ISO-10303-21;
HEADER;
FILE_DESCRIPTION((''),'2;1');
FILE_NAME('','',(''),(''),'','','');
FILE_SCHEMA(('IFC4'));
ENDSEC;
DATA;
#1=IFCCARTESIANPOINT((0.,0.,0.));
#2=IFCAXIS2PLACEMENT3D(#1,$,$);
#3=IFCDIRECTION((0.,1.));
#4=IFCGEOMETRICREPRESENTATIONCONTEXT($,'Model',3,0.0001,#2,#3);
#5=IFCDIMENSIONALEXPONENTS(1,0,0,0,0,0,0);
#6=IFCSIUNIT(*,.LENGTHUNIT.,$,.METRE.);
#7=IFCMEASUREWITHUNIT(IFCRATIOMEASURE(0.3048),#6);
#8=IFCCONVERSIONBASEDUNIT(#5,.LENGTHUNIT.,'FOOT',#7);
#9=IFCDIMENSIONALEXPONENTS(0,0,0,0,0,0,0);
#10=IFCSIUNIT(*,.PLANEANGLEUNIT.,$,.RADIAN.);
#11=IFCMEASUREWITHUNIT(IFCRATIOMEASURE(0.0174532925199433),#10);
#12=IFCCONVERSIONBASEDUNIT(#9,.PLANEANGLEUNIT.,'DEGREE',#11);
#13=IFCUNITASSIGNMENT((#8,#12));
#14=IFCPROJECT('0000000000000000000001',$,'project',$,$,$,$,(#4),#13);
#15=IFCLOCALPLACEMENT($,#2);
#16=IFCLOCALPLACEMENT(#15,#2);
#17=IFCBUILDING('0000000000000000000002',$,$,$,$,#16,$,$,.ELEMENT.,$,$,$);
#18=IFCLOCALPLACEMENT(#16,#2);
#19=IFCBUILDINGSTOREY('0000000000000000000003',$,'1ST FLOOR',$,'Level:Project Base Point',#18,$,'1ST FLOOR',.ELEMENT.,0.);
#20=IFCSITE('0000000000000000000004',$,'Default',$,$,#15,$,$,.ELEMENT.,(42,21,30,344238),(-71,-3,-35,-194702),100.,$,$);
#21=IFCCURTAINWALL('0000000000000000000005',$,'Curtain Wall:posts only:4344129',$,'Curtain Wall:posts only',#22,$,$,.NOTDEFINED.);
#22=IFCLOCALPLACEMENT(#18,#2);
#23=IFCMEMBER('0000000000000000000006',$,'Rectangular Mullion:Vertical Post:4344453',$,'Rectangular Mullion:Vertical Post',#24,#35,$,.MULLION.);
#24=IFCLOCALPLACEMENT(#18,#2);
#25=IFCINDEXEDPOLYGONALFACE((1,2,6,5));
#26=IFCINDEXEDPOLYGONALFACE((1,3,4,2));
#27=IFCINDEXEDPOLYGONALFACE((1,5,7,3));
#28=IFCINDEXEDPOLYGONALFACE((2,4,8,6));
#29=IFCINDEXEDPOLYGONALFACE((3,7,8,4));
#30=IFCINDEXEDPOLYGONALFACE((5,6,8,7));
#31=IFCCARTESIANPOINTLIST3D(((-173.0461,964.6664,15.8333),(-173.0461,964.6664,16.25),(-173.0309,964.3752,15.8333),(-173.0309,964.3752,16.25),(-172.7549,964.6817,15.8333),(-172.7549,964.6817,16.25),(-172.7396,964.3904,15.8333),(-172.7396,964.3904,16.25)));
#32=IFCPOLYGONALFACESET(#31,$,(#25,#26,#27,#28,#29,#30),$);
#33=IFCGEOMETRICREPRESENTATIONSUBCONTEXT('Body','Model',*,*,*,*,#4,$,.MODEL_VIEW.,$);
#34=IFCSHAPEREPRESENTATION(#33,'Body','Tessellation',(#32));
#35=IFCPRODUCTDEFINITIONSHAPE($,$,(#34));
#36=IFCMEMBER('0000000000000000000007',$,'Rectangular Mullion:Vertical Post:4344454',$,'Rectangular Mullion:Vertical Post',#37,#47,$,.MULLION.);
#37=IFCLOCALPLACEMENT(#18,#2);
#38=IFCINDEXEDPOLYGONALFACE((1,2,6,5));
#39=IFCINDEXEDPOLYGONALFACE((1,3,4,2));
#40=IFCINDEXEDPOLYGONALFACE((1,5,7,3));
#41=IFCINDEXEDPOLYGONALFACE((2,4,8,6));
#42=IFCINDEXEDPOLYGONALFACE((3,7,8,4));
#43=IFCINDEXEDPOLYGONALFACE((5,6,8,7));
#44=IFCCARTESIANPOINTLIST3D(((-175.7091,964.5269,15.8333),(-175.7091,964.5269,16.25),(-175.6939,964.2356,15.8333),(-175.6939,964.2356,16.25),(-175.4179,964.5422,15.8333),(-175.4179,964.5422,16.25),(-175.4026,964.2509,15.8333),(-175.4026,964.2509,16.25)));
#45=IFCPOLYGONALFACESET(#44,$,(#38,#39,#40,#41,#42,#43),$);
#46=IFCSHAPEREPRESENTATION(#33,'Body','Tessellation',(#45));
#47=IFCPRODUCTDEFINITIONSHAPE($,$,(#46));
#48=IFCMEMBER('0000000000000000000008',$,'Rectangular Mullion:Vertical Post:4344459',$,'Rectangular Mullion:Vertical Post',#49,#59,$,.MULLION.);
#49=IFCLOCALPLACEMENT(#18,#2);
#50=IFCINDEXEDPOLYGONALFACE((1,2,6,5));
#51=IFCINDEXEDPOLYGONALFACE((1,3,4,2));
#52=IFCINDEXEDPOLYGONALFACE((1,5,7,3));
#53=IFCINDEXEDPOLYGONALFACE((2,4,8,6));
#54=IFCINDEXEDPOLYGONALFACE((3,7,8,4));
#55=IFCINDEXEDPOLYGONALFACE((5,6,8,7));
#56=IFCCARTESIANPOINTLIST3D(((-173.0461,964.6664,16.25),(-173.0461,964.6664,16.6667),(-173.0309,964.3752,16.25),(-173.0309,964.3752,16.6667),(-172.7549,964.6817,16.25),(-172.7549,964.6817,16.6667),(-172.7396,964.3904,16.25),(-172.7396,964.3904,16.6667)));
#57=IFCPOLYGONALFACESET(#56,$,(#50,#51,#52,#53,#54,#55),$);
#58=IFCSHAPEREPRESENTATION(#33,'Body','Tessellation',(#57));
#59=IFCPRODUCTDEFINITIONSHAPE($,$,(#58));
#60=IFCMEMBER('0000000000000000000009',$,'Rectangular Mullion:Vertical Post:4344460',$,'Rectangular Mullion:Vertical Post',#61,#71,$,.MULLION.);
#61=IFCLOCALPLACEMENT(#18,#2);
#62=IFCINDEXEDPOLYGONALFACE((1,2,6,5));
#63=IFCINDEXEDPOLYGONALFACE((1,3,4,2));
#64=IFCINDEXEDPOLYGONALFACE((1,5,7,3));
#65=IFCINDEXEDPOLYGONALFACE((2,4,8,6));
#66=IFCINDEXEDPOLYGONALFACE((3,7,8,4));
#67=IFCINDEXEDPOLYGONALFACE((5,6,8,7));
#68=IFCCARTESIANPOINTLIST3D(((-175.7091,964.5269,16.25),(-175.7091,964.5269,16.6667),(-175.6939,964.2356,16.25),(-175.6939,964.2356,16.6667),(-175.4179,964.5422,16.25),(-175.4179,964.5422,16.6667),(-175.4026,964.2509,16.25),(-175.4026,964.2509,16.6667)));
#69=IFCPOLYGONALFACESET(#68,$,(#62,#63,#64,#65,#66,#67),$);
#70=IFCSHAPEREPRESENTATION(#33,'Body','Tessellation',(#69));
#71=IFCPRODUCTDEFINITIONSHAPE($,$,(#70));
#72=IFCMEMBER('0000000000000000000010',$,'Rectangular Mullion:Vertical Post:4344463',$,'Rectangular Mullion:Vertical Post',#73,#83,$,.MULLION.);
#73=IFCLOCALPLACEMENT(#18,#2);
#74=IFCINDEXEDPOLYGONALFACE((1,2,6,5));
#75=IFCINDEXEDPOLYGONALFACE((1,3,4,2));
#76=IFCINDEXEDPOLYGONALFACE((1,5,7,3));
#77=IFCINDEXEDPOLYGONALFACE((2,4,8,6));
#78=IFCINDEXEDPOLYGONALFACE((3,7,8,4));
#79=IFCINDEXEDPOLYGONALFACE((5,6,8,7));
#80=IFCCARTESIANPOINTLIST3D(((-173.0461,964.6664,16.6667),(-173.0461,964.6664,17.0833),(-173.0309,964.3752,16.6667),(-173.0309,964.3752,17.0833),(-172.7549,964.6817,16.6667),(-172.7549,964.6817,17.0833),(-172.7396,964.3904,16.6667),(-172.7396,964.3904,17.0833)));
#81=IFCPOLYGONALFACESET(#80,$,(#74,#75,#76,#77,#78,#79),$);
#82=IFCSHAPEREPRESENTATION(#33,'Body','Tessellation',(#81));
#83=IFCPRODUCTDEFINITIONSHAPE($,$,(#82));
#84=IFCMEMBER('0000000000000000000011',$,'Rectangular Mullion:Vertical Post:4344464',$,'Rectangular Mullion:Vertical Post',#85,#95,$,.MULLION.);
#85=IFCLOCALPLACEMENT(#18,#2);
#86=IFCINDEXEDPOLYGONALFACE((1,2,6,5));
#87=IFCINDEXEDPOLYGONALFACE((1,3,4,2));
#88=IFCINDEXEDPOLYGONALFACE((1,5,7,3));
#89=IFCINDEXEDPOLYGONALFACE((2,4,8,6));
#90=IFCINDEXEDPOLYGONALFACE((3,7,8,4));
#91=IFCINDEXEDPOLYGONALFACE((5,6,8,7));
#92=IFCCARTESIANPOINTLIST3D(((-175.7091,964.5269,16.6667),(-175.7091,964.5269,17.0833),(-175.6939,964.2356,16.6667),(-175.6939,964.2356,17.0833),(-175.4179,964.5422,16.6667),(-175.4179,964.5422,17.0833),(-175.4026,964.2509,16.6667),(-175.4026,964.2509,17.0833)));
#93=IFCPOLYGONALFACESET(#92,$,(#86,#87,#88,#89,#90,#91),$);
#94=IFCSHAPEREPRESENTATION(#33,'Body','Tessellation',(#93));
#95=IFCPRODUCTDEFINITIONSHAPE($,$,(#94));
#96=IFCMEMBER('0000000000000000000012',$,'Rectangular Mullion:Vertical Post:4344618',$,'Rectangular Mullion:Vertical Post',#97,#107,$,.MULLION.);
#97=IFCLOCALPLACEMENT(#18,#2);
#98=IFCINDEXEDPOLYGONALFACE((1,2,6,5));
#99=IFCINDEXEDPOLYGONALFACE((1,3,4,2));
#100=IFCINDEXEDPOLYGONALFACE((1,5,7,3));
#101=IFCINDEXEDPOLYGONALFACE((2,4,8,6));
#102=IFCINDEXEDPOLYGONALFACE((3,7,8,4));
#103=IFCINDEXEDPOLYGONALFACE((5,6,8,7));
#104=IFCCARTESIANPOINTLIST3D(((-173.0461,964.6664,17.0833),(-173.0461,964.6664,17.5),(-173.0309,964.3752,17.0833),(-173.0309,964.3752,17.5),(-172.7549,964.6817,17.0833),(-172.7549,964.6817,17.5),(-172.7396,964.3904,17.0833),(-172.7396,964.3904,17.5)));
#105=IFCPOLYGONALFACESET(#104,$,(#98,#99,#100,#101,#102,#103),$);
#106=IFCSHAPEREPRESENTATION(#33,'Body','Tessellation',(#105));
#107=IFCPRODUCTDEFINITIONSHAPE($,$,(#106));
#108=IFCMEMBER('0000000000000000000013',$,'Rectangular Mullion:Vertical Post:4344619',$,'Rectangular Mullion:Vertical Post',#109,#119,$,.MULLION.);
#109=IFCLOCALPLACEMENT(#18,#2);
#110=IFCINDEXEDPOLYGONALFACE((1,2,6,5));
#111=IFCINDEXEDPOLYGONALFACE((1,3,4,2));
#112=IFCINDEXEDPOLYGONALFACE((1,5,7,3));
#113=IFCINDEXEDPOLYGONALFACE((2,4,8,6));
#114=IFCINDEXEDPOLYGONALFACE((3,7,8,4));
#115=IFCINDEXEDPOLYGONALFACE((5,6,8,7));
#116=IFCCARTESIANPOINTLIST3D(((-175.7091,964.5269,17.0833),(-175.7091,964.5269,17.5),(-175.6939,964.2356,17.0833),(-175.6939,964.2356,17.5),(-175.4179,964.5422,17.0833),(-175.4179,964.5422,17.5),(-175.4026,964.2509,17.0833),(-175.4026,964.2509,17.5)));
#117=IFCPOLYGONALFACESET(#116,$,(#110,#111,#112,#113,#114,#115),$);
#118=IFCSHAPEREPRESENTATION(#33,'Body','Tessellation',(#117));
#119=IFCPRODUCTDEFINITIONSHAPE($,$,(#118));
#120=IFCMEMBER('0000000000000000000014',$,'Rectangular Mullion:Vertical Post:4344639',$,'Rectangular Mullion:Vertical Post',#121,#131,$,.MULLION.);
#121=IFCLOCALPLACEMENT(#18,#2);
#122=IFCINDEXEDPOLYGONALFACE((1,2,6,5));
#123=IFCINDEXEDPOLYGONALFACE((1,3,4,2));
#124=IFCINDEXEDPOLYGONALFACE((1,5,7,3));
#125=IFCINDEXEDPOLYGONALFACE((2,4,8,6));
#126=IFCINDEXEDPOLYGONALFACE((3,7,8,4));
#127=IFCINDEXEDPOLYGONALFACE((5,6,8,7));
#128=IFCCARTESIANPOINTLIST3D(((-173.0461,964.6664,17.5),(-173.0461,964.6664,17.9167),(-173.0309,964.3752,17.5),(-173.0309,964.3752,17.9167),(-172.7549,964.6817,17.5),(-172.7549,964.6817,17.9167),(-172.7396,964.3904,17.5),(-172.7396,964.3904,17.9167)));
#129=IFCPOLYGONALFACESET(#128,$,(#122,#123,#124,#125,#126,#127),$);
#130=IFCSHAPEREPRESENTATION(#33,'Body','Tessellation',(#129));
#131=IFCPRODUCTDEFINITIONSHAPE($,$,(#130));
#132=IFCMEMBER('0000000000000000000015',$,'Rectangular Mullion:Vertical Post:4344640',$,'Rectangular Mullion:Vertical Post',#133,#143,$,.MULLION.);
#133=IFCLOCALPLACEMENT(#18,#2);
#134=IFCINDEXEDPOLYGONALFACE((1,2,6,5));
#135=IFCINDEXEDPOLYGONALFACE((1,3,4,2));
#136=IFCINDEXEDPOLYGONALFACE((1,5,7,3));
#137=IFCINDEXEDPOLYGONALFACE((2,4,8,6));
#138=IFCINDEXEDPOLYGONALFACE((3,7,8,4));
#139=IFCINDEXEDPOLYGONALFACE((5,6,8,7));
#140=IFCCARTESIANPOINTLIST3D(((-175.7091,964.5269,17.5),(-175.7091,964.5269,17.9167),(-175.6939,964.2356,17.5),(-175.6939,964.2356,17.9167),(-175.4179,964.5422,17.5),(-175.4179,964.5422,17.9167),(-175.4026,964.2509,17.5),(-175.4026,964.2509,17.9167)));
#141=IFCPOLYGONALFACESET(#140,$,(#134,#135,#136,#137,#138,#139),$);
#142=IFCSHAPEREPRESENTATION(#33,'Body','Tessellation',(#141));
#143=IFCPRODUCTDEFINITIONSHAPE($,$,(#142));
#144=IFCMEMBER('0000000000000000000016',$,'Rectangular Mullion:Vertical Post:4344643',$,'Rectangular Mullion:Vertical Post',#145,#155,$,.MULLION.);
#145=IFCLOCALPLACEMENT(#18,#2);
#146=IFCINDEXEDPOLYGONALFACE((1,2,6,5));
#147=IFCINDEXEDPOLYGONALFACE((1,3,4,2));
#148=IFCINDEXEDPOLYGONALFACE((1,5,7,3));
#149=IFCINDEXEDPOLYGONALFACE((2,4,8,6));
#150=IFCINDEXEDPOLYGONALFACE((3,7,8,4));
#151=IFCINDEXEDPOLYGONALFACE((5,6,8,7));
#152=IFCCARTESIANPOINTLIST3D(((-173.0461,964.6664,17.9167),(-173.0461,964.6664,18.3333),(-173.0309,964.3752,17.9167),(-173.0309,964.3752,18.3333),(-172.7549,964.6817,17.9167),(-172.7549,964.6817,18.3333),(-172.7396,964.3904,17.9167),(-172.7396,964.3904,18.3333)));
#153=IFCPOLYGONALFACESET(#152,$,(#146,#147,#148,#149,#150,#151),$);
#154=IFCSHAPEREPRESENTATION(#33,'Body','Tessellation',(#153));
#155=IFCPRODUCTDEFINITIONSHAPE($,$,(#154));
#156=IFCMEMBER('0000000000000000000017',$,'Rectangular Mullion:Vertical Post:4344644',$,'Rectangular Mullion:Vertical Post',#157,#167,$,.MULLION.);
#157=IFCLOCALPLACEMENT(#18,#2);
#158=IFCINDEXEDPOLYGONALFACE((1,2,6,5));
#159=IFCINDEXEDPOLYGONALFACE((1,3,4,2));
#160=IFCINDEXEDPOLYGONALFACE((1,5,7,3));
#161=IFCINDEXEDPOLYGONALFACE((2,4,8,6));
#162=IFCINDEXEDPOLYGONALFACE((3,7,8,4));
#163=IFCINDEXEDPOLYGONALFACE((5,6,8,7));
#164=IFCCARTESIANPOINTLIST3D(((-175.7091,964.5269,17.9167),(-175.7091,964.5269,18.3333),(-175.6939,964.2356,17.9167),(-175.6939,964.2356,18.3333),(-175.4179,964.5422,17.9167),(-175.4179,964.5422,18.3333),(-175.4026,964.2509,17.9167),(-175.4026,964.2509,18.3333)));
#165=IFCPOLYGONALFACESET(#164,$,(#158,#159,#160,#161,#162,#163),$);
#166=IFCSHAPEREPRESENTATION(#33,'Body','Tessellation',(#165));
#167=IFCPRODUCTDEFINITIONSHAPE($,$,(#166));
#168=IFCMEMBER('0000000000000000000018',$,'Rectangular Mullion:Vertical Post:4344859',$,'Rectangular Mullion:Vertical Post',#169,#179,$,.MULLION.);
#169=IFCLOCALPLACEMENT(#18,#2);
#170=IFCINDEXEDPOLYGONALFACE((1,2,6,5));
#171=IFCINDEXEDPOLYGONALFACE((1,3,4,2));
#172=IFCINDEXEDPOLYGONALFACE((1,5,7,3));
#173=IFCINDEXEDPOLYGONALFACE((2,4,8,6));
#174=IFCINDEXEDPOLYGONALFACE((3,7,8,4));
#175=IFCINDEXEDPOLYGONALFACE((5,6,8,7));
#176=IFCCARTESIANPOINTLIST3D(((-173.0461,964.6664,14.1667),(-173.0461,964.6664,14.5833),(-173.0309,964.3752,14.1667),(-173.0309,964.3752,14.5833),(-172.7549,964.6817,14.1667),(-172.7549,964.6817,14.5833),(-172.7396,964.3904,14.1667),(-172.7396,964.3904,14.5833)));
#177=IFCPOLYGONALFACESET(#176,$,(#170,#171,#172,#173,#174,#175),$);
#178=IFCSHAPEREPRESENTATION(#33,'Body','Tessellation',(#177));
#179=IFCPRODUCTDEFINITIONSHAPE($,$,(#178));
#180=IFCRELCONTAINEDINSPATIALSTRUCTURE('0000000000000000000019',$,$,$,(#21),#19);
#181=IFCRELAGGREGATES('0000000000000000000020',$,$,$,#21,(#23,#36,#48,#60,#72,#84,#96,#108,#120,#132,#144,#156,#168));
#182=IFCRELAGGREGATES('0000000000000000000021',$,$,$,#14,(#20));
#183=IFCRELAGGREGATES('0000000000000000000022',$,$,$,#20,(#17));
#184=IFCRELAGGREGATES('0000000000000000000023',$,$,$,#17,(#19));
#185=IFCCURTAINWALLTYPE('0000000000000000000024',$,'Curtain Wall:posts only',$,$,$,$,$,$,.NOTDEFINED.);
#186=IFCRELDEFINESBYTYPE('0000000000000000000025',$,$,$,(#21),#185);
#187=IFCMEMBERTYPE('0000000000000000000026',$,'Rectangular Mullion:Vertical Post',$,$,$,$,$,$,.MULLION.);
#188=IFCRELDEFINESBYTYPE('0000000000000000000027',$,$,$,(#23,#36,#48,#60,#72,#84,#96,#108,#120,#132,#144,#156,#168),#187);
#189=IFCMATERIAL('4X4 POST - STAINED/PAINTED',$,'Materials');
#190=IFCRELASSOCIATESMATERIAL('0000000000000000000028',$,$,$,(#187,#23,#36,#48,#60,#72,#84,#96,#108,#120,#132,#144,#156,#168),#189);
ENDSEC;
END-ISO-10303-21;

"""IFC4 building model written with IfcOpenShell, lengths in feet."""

from ifc_helpers import new_model, entity, si_unit, converted_unit, direction, frame, origin, origin_2d_with_axis, place, context, subcontext, project, spatial, rectangle, extrude, source, transform, mapped, material, material_profile, profile_set, profile_usage, type_object, type_shapes, element, aggregate, save


model = new_model("IFC4")

# Units and contexts
model_context = context("Model", 3, precision=0.0001, world=origin(), true_north=direction((0.0, 1.0)))
body_context = subcontext(model_context, "Body", "Model", "MODEL_VIEW")
ifc_project = project(units=[converted_unit("LENGTHUNIT", "FOOT", entity("IfcRatioMeasure", 0.3048), si_unit("LENGTHUNIT", "METRE"), dimensions=[1, 0, 0, 0, 0, 0, 0]), converted_unit("PLANEANGLEUNIT", "DEGREE", entity("IfcRatioMeasure", 0.0174532925199433), si_unit("PLANEANGLEUNIT", "RADIAN"), dimensions=[0, 0, 0, 0, 0, 0, 0])], contexts=[model_context])

# Site, building, storey
site_placement = place(None, origin())
site = spatial("IfcSite", under=ifc_project, at=site_placement, Name="Default", CompositionType="ELEMENT", RefLatitude=(42, 21, 30, 344238), RefLongitude=(-71, -3, -35, -194702), RefElevation=100.0)
building_placement = place(site_placement, origin())
building = spatial("IfcBuilding", under=site, at=building_placement, CompositionType="ELEMENT")
storey_placement = place(building_placement, origin())
storey = spatial("IfcBuildingStorey", under=building, at=storey_placement, Name="1ST FLOOR", ObjectType="Level:Project Base Point", LongName="1ST FLOOR", CompositionType="ELEMENT", Elevation=0.0)

# Curtain wall, members
curtain_wall_type_1 = type_object("IfcCurtainWallType", Name="Curtain Wall:posts only", PredefinedType="NOTDEFINED")
curtain_wall_1_placement = place(storey_placement, origin())
curtain_wall_1 = element("IfcCurtainWall", 1, at=curtain_wall_1_placement, inside=storey, type_object=curtain_wall_type_1, Name="Curtain Wall:posts only:4344129", ObjectType="Curtain Wall:posts only", PredefinedType="NOTDEFINED")
ifc_material_1 = material(Name="4X4 POST - STAINED/PAINTED", Category="Materials")
ifc_material_profile_1 = material_profile(ifc_material_1, rectangle(XDim=0.2917, YDim=0.2917, at=origin_2d_with_axis()), Name="Vertical Post")
ifc_profile_set_1 = profile_set([ifc_material_profile_1], Name="Vertical Post")
member_type_1 = type_object("IfcMemberType", Name="Rectangular Mullion:Vertical Post", PredefinedType="MULLION", material=ifc_profile_set_1)
shared_shape_1 = source(origin(), body_context, "Body", "SweptSolid", [
    extrude(rectangle(XDim=0.2917, YDim=0.2917, at=origin_2d_with_axis()), frame((0.0, -0.2083, -0.4167), z_axis=(0.0, 0.0, 1.0), x_axis=(0.0, -1.0, 0.0)), (0.0, 0.0, 1.0), 0.4167),
])
type_shapes(member_type_1, [shared_shape_1])
ifc_profile_usage_1 = profile_usage(ifc_profile_set_1)
member_1_placement = place(storey_placement, frame((-172.9038, 964.7365, 15.8333), z_axis=(0.0, 0.0, -1.0), x_axis=(-0.99863, -0.052336, 0.0)))
member_1 = element("IfcMember", 2, at=member_1_placement, type_object=member_type_1, material=ifc_profile_usage_1, Name="Rectangular Mullion:Vertical Post:4344453", ObjectType="Rectangular Mullion:Vertical Post", PredefinedType="MULLION", context=body_context, shape_type="MappedRepresentation", body=[
    mapped(shared_shape_1, transform((0.0, 0.0, 0.0), scale=1.0)),
])
ifc_profile_usage_2 = profile_usage(ifc_profile_set_1)
member_2_placement = place(storey_placement, frame((-175.5668, 964.5969, 15.8333), z_axis=(0.0, 0.0, -1.0), x_axis=(-0.99863, -0.052336, 0.0)))
member_2 = element("IfcMember", 3, at=member_2_placement, type_object=member_type_1, material=ifc_profile_usage_2, Name="Rectangular Mullion:Vertical Post:4344454", ObjectType="Rectangular Mullion:Vertical Post", PredefinedType="MULLION", context=body_context, shape_type="MappedRepresentation", body=[
    mapped(shared_shape_1, transform((0.0, 0.0, 0.0), scale=1.0)),
])
ifc_profile_usage_3 = profile_usage(ifc_profile_set_1)
member_3_placement = place(storey_placement, frame((-172.9038, 964.7365, 16.25), z_axis=(0.0, 0.0, -1.0), x_axis=(-0.99863, -0.052336, 0.0)))
member_3 = element("IfcMember", 4, at=member_3_placement, type_object=member_type_1, material=ifc_profile_usage_3, Name="Rectangular Mullion:Vertical Post:4344459", ObjectType="Rectangular Mullion:Vertical Post", PredefinedType="MULLION", context=body_context, shape_type="MappedRepresentation", body=[
    mapped(shared_shape_1, transform((0.0, 0.0, 0.0), scale=1.0)),
])
ifc_profile_usage_4 = profile_usage(ifc_profile_set_1)
member_4_placement = place(storey_placement, frame((-175.5668, 964.5969, 16.25), z_axis=(0.0, 0.0, -1.0), x_axis=(-0.99863, -0.052336, 0.0)))
member_4 = element("IfcMember", 5, at=member_4_placement, type_object=member_type_1, material=ifc_profile_usage_4, Name="Rectangular Mullion:Vertical Post:4344460", ObjectType="Rectangular Mullion:Vertical Post", PredefinedType="MULLION", context=body_context, shape_type="MappedRepresentation", body=[
    mapped(shared_shape_1, transform((0.0, 0.0, 0.0), scale=1.0)),
])
ifc_profile_usage_5 = profile_usage(ifc_profile_set_1)
member_5_placement = place(storey_placement, frame((-172.9038, 964.7365, 16.6667), z_axis=(0.0, 0.0, -1.0), x_axis=(-0.99863, -0.052336, 0.0)))
member_5 = element("IfcMember", 6, at=member_5_placement, type_object=member_type_1, material=ifc_profile_usage_5, Name="Rectangular Mullion:Vertical Post:4344463", ObjectType="Rectangular Mullion:Vertical Post", PredefinedType="MULLION", context=body_context, shape_type="MappedRepresentation", body=[
    mapped(shared_shape_1, transform((0.0, 0.0, 0.0), scale=1.0)),
])
ifc_profile_usage_6 = profile_usage(ifc_profile_set_1)
member_6_placement = place(storey_placement, frame((-175.5668, 964.5969, 16.6667), z_axis=(0.0, 0.0, -1.0), x_axis=(-0.99863, -0.052336, 0.0)))
member_6 = element("IfcMember", 7, at=member_6_placement, type_object=member_type_1, material=ifc_profile_usage_6, Name="Rectangular Mullion:Vertical Post:4344464", ObjectType="Rectangular Mullion:Vertical Post", PredefinedType="MULLION", context=body_context, shape_type="MappedRepresentation", body=[
    mapped(shared_shape_1, transform((0.0, 0.0, 0.0), scale=1.0)),
])
ifc_profile_usage_7 = profile_usage(ifc_profile_set_1)
member_7_placement = place(storey_placement, frame((-172.9038, 964.7365, 17.0833), z_axis=(0.0, 0.0, -1.0), x_axis=(-0.99863, -0.052336, 0.0)))
member_7 = element("IfcMember", 8, at=member_7_placement, type_object=member_type_1, material=ifc_profile_usage_7, Name="Rectangular Mullion:Vertical Post:4344618", ObjectType="Rectangular Mullion:Vertical Post", PredefinedType="MULLION", context=body_context, shape_type="MappedRepresentation", body=[
    mapped(shared_shape_1, transform((0.0, 0.0, 0.0), scale=1.0)),
])
ifc_profile_usage_8 = profile_usage(ifc_profile_set_1)
member_8_placement = place(storey_placement, frame((-175.5668, 964.5969, 17.0833), z_axis=(0.0, 0.0, -1.0), x_axis=(-0.99863, -0.052336, 0.0)))
member_8 = element("IfcMember", 9, at=member_8_placement, type_object=member_type_1, material=ifc_profile_usage_8, Name="Rectangular Mullion:Vertical Post:4344619", ObjectType="Rectangular Mullion:Vertical Post", PredefinedType="MULLION", context=body_context, shape_type="MappedRepresentation", body=[
    mapped(shared_shape_1, transform((0.0, 0.0, 0.0), scale=1.0)),
])
ifc_profile_usage_9 = profile_usage(ifc_profile_set_1)
member_9_placement = place(storey_placement, frame((-172.9038, 964.7365, 17.5), z_axis=(0.0, 0.0, -1.0), x_axis=(-0.99863, -0.052336, 0.0)))
member_9 = element("IfcMember", 10, at=member_9_placement, type_object=member_type_1, material=ifc_profile_usage_9, Name="Rectangular Mullion:Vertical Post:4344639", ObjectType="Rectangular Mullion:Vertical Post", PredefinedType="MULLION", context=body_context, shape_type="MappedRepresentation", body=[
    mapped(shared_shape_1, transform((0.0, 0.0, 0.0), scale=1.0)),
])
ifc_profile_usage_10 = profile_usage(ifc_profile_set_1)
member_10_placement = place(storey_placement, frame((-175.5668, 964.5969, 17.5), z_axis=(0.0, 0.0, -1.0), x_axis=(-0.99863, -0.052336, 0.0)))
member_10 = element("IfcMember", 11, at=member_10_placement, type_object=member_type_1, material=ifc_profile_usage_10, Name="Rectangular Mullion:Vertical Post:4344640", ObjectType="Rectangular Mullion:Vertical Post", PredefinedType="MULLION", context=body_context, shape_type="MappedRepresentation", body=[
    mapped(shared_shape_1, transform((0.0, 0.0, 0.0), scale=1.0)),
])
ifc_profile_usage_11 = profile_usage(ifc_profile_set_1)
member_11_placement = place(storey_placement, frame((-172.9038, 964.7365, 17.9167), z_axis=(0.0, 0.0, -1.0), x_axis=(-0.99863, -0.052336, 0.0)))
member_11 = element("IfcMember", 12, at=member_11_placement, type_object=member_type_1, material=ifc_profile_usage_11, Name="Rectangular Mullion:Vertical Post:4344643", ObjectType="Rectangular Mullion:Vertical Post", PredefinedType="MULLION", context=body_context, shape_type="MappedRepresentation", body=[
    mapped(shared_shape_1, transform((0.0, 0.0, 0.0), scale=1.0)),
])
ifc_profile_usage_12 = profile_usage(ifc_profile_set_1)
member_12_placement = place(storey_placement, frame((-175.5668, 964.5969, 17.9167), z_axis=(0.0, 0.0, -1.0), x_axis=(-0.99863, -0.052336, 0.0)))
member_12 = element("IfcMember", 13, at=member_12_placement, type_object=member_type_1, material=ifc_profile_usage_12, Name="Rectangular Mullion:Vertical Post:4344644", ObjectType="Rectangular Mullion:Vertical Post", PredefinedType="MULLION", context=body_context, shape_type="MappedRepresentation", body=[
    mapped(shared_shape_1, transform((0.0, 0.0, 0.0), scale=1.0)),
])
ifc_profile_usage_13 = profile_usage(ifc_profile_set_1)
member_13_placement = place(storey_placement, frame((-172.9038, 964.7365, 14.1667), z_axis=(0.0, 0.0, -1.0), x_axis=(-0.99863, -0.052336, 0.0)))
member_13 = element("IfcMember", 14, at=member_13_placement, type_object=member_type_1, material=ifc_profile_usage_13, Name="Rectangular Mullion:Vertical Post:4344859", ObjectType="Rectangular Mullion:Vertical Post", PredefinedType="MULLION", context=body_context, shape_type="MappedRepresentation", body=[
    mapped(shared_shape_1, transform((0.0, 0.0, 0.0), scale=1.0)),
])
aggregate(curtain_wall_1, [member_1, member_2, member_3, member_4, member_5, member_6, member_7, member_8, member_9, member_10, member_11, member_12, member_13])

save(model, "model.ifc")
